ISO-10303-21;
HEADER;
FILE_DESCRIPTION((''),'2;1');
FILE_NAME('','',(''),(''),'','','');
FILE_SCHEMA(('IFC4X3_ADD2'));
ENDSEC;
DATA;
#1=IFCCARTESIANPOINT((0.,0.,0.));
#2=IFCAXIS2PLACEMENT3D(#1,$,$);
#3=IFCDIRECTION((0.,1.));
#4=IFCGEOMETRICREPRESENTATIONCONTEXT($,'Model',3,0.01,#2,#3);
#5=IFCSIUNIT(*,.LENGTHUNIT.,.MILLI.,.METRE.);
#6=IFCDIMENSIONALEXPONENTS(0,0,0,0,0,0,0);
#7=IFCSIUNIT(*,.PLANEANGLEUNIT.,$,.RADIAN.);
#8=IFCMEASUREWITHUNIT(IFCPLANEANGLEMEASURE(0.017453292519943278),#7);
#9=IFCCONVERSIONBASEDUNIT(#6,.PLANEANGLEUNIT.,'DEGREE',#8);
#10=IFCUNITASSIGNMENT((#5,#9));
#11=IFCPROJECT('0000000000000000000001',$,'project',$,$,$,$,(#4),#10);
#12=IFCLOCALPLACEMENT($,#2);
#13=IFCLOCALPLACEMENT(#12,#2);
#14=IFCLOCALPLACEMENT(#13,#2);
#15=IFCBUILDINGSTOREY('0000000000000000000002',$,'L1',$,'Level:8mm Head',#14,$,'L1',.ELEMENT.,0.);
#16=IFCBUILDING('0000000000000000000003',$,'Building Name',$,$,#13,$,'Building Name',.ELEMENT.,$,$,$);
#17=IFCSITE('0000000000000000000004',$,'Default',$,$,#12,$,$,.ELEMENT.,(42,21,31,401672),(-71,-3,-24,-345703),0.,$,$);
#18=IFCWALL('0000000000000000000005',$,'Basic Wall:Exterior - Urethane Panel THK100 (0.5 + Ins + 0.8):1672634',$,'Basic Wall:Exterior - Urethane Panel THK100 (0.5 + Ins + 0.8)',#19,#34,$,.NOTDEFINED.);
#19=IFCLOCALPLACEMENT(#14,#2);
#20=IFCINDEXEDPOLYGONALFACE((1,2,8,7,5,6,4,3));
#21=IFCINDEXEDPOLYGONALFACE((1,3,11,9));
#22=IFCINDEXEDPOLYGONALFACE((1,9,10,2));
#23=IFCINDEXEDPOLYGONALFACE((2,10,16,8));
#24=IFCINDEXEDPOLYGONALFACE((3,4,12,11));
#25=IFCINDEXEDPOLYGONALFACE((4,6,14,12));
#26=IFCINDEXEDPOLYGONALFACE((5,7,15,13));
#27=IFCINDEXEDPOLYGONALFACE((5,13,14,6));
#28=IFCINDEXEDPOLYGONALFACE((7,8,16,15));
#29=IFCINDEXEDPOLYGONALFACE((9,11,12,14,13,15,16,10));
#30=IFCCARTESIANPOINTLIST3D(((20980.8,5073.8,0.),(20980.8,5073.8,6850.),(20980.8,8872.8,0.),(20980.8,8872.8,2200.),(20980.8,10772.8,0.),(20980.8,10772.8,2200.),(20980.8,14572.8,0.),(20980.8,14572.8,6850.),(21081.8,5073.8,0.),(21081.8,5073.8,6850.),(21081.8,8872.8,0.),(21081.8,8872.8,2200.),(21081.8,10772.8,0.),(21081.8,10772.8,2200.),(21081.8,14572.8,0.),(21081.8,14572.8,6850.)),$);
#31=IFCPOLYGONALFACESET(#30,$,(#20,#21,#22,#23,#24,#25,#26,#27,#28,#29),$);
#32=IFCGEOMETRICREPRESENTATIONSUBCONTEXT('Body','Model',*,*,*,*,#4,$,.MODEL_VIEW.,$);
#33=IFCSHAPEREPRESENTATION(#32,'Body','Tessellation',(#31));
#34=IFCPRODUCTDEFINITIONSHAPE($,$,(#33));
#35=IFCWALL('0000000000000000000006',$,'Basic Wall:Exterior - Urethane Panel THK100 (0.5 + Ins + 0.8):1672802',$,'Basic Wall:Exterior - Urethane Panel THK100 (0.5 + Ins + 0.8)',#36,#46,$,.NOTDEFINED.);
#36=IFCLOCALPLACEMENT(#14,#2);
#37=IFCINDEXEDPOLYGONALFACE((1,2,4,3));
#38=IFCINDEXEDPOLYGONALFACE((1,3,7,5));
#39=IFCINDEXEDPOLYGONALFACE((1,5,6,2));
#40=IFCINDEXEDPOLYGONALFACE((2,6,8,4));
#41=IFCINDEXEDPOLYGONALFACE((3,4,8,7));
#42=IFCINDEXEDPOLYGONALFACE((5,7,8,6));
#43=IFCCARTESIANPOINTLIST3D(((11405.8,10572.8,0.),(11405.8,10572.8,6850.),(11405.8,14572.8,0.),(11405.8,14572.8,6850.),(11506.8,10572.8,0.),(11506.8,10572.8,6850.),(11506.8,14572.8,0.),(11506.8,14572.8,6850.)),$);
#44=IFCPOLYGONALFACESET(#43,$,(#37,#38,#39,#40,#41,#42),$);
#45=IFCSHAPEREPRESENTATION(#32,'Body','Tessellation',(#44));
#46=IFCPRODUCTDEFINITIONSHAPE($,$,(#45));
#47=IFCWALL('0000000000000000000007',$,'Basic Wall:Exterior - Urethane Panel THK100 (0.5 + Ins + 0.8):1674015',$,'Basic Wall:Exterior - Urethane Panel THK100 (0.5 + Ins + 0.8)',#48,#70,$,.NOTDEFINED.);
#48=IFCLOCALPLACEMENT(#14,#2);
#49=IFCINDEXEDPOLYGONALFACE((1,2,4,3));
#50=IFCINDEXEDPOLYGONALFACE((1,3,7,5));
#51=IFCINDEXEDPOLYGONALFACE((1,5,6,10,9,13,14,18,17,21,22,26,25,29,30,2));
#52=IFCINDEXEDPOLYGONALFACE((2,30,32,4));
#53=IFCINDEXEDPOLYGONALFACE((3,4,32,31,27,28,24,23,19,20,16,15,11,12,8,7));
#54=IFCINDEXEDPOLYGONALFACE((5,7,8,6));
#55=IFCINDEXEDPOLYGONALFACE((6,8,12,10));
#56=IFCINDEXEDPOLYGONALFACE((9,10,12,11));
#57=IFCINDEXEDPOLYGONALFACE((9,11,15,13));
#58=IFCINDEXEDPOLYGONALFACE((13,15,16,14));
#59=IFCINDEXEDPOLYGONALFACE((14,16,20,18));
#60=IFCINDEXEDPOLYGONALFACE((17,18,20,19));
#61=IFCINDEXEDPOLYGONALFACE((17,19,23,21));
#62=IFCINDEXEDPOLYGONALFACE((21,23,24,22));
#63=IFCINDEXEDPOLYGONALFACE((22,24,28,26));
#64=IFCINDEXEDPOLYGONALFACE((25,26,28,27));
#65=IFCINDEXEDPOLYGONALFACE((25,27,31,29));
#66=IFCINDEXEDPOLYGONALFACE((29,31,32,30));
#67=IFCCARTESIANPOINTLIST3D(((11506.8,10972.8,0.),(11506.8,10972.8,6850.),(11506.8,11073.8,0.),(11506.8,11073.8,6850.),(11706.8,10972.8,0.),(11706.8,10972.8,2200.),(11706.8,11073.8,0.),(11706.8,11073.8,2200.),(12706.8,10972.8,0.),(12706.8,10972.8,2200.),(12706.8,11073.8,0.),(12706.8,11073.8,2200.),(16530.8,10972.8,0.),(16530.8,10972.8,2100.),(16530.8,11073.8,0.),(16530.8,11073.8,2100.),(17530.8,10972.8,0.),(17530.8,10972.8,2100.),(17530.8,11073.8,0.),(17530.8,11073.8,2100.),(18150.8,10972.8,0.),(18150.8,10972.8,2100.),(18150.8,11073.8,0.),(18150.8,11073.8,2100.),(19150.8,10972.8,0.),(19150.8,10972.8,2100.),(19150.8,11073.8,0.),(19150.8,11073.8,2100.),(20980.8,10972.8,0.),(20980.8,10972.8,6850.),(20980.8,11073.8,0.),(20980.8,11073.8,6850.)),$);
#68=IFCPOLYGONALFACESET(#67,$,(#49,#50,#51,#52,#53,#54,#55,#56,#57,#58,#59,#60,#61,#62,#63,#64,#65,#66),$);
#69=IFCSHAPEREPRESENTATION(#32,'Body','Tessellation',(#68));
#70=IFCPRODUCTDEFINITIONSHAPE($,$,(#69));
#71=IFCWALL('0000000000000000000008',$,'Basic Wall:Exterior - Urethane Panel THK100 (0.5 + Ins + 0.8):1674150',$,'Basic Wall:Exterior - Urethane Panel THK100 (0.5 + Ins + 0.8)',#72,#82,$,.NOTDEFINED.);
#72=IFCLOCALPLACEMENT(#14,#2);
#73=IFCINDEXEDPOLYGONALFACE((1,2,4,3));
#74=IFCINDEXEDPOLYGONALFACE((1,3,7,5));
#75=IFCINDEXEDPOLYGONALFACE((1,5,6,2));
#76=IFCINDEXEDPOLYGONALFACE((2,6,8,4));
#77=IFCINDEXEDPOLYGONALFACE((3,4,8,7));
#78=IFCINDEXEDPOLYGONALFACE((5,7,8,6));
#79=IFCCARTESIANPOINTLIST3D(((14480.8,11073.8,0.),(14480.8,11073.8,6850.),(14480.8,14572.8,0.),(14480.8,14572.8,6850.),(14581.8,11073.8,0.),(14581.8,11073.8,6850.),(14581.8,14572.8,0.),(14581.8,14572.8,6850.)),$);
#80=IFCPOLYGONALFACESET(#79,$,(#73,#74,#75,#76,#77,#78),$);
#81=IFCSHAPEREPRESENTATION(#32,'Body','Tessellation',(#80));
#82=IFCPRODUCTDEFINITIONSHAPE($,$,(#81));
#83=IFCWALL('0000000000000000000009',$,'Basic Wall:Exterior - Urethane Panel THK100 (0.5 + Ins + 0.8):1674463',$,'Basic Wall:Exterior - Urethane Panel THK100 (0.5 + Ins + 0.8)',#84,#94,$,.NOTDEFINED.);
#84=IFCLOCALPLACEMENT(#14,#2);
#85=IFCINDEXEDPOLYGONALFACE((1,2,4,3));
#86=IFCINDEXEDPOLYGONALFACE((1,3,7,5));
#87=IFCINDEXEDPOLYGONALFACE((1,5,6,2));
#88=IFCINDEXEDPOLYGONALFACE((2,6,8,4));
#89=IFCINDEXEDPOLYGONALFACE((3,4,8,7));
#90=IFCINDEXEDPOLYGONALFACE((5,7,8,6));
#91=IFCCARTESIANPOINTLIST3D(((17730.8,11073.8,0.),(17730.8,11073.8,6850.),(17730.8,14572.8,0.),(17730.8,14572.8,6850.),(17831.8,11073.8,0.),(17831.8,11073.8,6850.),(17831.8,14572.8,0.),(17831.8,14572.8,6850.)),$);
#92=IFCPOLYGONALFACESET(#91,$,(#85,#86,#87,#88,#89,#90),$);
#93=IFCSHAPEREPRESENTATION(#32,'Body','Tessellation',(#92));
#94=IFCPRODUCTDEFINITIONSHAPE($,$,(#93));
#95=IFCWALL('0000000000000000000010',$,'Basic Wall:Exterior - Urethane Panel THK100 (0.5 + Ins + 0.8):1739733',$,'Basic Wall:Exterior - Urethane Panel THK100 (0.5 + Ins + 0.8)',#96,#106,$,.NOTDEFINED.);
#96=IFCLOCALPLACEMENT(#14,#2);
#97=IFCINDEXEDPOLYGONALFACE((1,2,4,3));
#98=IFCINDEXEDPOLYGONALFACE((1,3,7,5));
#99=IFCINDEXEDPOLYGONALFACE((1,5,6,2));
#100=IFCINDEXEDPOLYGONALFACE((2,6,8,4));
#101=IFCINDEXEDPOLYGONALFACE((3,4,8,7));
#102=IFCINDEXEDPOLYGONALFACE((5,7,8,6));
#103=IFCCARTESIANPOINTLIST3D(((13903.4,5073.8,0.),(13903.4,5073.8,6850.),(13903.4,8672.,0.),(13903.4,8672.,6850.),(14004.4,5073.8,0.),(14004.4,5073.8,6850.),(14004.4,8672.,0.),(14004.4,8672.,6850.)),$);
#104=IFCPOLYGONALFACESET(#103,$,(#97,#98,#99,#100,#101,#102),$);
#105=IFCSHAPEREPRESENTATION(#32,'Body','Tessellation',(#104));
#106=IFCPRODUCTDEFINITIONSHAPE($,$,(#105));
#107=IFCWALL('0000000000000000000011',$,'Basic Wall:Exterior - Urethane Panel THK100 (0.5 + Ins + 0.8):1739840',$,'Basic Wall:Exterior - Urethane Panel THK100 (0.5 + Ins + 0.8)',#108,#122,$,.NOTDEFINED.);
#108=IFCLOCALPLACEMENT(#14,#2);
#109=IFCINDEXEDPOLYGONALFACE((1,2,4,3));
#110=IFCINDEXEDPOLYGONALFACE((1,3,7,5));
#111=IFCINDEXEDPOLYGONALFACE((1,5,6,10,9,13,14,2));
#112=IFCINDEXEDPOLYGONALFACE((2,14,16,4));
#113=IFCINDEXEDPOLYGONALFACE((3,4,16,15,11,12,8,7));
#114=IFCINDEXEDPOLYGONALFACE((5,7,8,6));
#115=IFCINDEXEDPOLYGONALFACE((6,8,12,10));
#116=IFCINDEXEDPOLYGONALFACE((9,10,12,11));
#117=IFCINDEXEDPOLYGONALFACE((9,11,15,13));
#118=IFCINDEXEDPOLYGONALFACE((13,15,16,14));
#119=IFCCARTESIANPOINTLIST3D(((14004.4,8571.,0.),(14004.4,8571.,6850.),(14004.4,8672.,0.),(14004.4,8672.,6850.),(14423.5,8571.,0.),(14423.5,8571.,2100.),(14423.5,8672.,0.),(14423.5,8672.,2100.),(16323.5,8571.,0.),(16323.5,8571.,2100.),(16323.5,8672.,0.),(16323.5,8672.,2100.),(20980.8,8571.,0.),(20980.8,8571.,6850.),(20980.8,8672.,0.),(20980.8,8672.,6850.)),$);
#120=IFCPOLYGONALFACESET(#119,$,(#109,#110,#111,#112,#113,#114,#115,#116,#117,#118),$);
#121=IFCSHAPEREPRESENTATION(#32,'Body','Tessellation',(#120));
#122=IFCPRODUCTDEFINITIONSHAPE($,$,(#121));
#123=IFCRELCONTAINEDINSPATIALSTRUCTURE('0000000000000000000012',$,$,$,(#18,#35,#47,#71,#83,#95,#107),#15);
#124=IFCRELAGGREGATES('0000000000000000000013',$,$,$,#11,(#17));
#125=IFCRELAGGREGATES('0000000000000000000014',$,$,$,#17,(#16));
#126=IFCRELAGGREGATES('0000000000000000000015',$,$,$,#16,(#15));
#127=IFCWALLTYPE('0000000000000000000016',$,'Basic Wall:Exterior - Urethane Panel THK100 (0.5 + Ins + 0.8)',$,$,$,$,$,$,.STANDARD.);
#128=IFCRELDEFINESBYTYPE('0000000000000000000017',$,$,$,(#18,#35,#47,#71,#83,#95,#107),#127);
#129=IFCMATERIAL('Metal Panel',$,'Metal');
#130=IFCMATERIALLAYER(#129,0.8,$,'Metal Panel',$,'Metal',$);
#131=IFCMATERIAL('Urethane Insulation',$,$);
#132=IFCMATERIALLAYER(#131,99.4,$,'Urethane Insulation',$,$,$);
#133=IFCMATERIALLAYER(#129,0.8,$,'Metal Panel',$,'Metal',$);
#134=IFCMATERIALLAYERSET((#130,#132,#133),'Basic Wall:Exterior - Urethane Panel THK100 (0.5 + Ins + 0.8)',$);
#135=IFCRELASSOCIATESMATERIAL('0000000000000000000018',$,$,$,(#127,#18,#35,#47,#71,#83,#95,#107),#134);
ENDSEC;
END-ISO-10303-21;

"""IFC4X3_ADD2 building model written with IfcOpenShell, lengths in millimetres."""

from ifc_helpers import new_model, entity, si_unit, converted_unit, direction, frame, frame_2d, origin, place, context, subcontext, project, spatial, polyline, rectangle, extrude, clip, bounded_halfspace, material, layer, layer_set, type_object, element, save


model = new_model("IFC4X3_ADD2")

# Units and contexts
model_context = context("Model", 3, precision=0.01, world=origin(), true_north=direction((0.0, 1.0)))
body_context = subcontext(model_context, "Body", "Model", "MODEL_VIEW")
ifc_project = project(units=[si_unit("LENGTHUNIT", "METRE", prefix="MILLI"), converted_unit("PLANEANGLEUNIT", "DEGREE", entity("IfcPlaneAngleMeasure", 0.017453292519943278), si_unit("PLANEANGLEUNIT", "RADIAN"), dimensions=[0, 0, 0, 0, 0, 0, 0])], contexts=[model_context])

# Site, building, storey
site_placement = place(None, origin())
site = spatial("IfcSite", under=ifc_project, at=site_placement, Name="Default", CompositionType="ELEMENT", RefLatitude=(42, 21, 31, 401672), RefLongitude=(-71, -3, -24, -345703), RefElevation=0.0)
building_placement = place(site_placement, origin())
building = spatial("IfcBuilding", under=site, at=building_placement, Name="Building Name", LongName="Building Name", CompositionType="ELEMENT")
storey_placement = place(building_placement, origin())
storey = spatial("IfcBuildingStorey", under=building, at=storey_placement, Name="L1", ObjectType="Level:8mm Head", LongName="L1", CompositionType="ELEMENT", Elevation=0.0)

# Wall, opening
ifc_material_1 = material(Name="Metal Panel", Category="Metal")
ifc_layer_1 = layer(ifc_material_1, 0.8, Name="Metal Panel", Category="Metal")
ifc_material_2 = material(Name="Urethane Insulation")
ifc_layer_2 = layer(ifc_material_2, 99.4, Name="Urethane Insulation")
ifc_layer_3 = layer(ifc_material_1, 0.8, Name="Metal Panel", Category="Metal")
ifc_layer_set = layer_set([ifc_layer_1, ifc_layer_2, ifc_layer_3], Name="Basic Wall:Exterior - Urethane Panel THK100 (0.5 + Ins + 0.8)")
wall_type = type_object("IfcWallType", Name="Basic Wall:Exterior - Urethane Panel THK100 (0.5 + Ins + 0.8)", PredefinedType="STANDARD", material=ifc_layer_set)
wall_1_placement = place(storey_placement, frame((21031.3, 5073.8, 0.0), z_axis=(0.0, 0.0, 1.0), x_axis=(0.0, 1.0, 0.0)))
wall_1 = element("IfcWall", 1, at=wall_1_placement, inside=storey, type_object=wall_type, material=ifc_layer_set, Name="Basic Wall:Exterior - Urethane Panel THK100 (0.5 + Ins + 0.8):1672634", ObjectType="Basic Wall:Exterior - Urethane Panel THK100 (0.5 + Ins + 0.8)", PredefinedType="NOTDEFINED", context=body_context, shape_type="Clipping", body=[
    clip(extrude(rectangle(XDim=9499.0, YDim=101.0, at=frame_2d((4749.5, 0.0), x_axis=(-1.0, 0.0))), origin(), (0.0, 0.0, 1.0), 6850.0), bounded_halfspace(frame((0.0, -50.5, 6850.0), z_axis=(0.0, 0.0, -1.0), x_axis=(0.0, -1.0, 0.0)), True, frame((0.0, -50.5, 6850.0)), polyline([(0.0, 0.0), (9499.0, 0.0), (9499.0, 101.0), (6000.0, 101.0), (5899.0, 101.0), (3598.2, 101.0), (3497.2, 101.0), (0.0, 101.0), (0.0, 0.0)]))),
])
opening_1_placement = place(wall_1_placement, frame((3799.0, -50.5, 0.0)))
element("IfcOpeningElement", 2, at=opening_1_placement, cuts=wall_1, PredefinedType="OPENING", context=body_context, shape_type="SweptSolid", body=[
    extrude(rectangle(XDim=2200.0, YDim=1900.0, at=frame_2d((1100.0, 950.0), x_axis=(1.0, 0.0))), frame((0.0, 0.0, 0.0), z_axis=(0.0, 1.0, 0.0), x_axis=(0.0, 0.0, 1.0)), (0.0, 0.0, 1.0), 101.0),
])

# Wall
wall_2_placement = place(storey_placement, frame((11456.3, 14572.8, 0.0), z_axis=(0.0, 0.0, 1.0), x_axis=(0.0, -1.0, 0.0)))
element("IfcWall", 3, at=wall_2_placement, inside=storey, type_object=wall_type, material=ifc_layer_set, Name="Basic Wall:Exterior - Urethane Panel THK100 (0.5 + Ins + 0.8):1672802", ObjectType="Basic Wall:Exterior - Urethane Panel THK100 (0.5 + Ins + 0.8)", PredefinedType="NOTDEFINED", context=body_context, shape_type="Clipping", body=[
    clip(extrude(rectangle(XDim=4000.0, YDim=101.0, at=frame_2d((2000.0, 0.0), x_axis=(-1.0, 0.0))), origin(), (0.0, 0.0, 1.0), 6850.0), bounded_halfspace(frame((0.0, -50.5, 6850.0), z_axis=(0.0, 0.0, -1.0), x_axis=(0.0, 1.0, 0.0)), True, frame((0.0, -50.5, 6850.0)), polyline([(0.0, 0.0), (3899.0, 0.0), (4000.0, 0.0), (4000.0, 101.0), (3600.0, 101.0), (3499.0, 101.0), (0.0, 101.0), (0.0, 0.0)]))),
])

# Wall, openings
wall_3_placement = place(storey_placement, frame((11506.8, 11023.3, 0.0)))
wall_3 = element("IfcWall", 4, at=wall_3_placement, inside=storey, type_object=wall_type, material=ifc_layer_set, Name="Basic Wall:Exterior - Urethane Panel THK100 (0.5 + Ins + 0.8):1674015", ObjectType="Basic Wall:Exterior - Urethane Panel THK100 (0.5 + Ins + 0.8)", PredefinedType="NOTDEFINED", context=body_context, shape_type="Clipping", body=[
    clip(extrude(rectangle(XDim=9474.0, YDim=101.0, at=frame_2d((4737.0, 0.0), x_axis=(1.0, 0.0))), origin(), (0.0, 0.0, 1.0), 6850.0), bounded_halfspace(frame((0.0, -50.5, 6850.0), z_axis=(0.0, 0.0, -1.0), x_axis=(1.0, 0.0, 0.0)), True, frame((0.0, -50.5, 6850.0)), polyline([(0.0, 0.0), (9474.0, 0.0), (9474.0, 101.0), (6325.0, 101.0), (6224.0, 101.0), (3075.0, 101.0), (2974.0, 101.0), (0.0, 101.0), (0.0, 0.0)]))),
])
opening_2_placement = place(wall_3_placement, frame((200.0, -50.5, 0.0)))
element("IfcOpeningElement", 5, at=opening_2_placement, cuts=wall_3, PredefinedType="OPENING", context=body_context, shape_type="SweptSolid", body=[
    extrude(rectangle(XDim=2200.0, YDim=1000.0, at=frame_2d((1100.0, 500.0), x_axis=(1.0, 0.0))), frame((0.0, 0.0, 0.0), z_axis=(0.0, 1.0, 0.0), x_axis=(0.0, 0.0, 1.0)), (0.0, 0.0, 1.0), 101.0),
])
opening_3_placement = place(wall_3_placement, frame((5024.0, -50.5, 0.0)))
element("IfcOpeningElement", 6, at=opening_3_placement, cuts=wall_3, PredefinedType="OPENING", context=body_context, shape_type="SweptSolid", body=[
    extrude(rectangle(XDim=2100.0, YDim=1000.0, at=frame_2d((1050.0, 500.0), x_axis=(1.0, 0.0))), frame((0.0, 0.0, 0.0), z_axis=(0.0, 1.0, 0.0), x_axis=(0.0, 0.0, 1.0)), (0.0, 0.0, 1.0), 101.0),
])
opening_4_placement = place(wall_3_placement, frame((6644.0, -50.5, 0.0)))
element("IfcOpeningElement", 7, at=opening_4_placement, cuts=wall_3, PredefinedType="OPENING", context=body_context, shape_type="SweptSolid", body=[
    extrude(rectangle(XDim=2100.0, YDim=1000.0, at=frame_2d((1050.0, 500.0), x_axis=(1.0, 0.0))), frame((0.0, 0.0, 0.0), z_axis=(0.0, 1.0, 0.0), x_axis=(0.0, 0.0, 1.0)), (0.0, 0.0, 1.0), 101.0),
])

# Walls
wall_4_placement = place(storey_placement, frame((14531.3, 11073.8, 0.0), z_axis=(0.0, 0.0, 1.0), x_axis=(0.0, 1.0, 0.0)))
element("IfcWall", 8, at=wall_4_placement, inside=storey, type_object=wall_type, material=ifc_layer_set, Name="Basic Wall:Exterior - Urethane Panel THK100 (0.5 + Ins + 0.8):1674150", ObjectType="Basic Wall:Exterior - Urethane Panel THK100 (0.5 + Ins + 0.8)", PredefinedType="NOTDEFINED", context=body_context, shape_type="Clipping", body=[
    clip(extrude(rectangle(XDim=3499.0, YDim=101.0, at=frame_2d((1749.5, 0.0), x_axis=(-1.0, 0.0))), origin(), (0.0, 0.0, 1.0), 6850.0), bounded_halfspace(frame((0.0, -50.5, 6850.0), z_axis=(0.0, 0.0, -1.0), x_axis=(0.0, -1.0, 0.0)), True, frame((0.0, -50.5, 6850.0)), polyline([(0.0, 0.0), (3499.0, 0.0), (3499.0, 101.0), (0.0, 101.0), (0.0, 0.0)]))),
])
wall_5_placement = place(storey_placement, frame((17781.3, 14572.8, 0.0), z_axis=(0.0, 0.0, 1.0), x_axis=(0.0, -1.0, 0.0)))
element("IfcWall", 9, at=wall_5_placement, inside=storey, type_object=wall_type, material=ifc_layer_set, Name="Basic Wall:Exterior - Urethane Panel THK100 (0.5 + Ins + 0.8):1674463", ObjectType="Basic Wall:Exterior - Urethane Panel THK100 (0.5 + Ins + 0.8)", PredefinedType="NOTDEFINED", context=body_context, shape_type="Clipping", body=[
    clip(extrude(rectangle(XDim=3499.0, YDim=101.0, at=frame_2d((1749.5, 0.0), x_axis=(-1.0, 0.0))), origin(), (0.0, 0.0, 1.0), 6850.0), bounded_halfspace(frame((0.0, -50.5, 6850.0), z_axis=(0.0, 0.0, -1.0), x_axis=(0.0, 1.0, 0.0)), True, frame((0.0, -50.5, 6850.0)), polyline([(0.0, 0.0), (3499.0, 0.0), (3499.0, 101.0), (0.0, 101.0), (0.0, 0.0)]))),
])
wall_6_placement = place(storey_placement, frame((13953.9, 5073.8, 0.0), z_axis=(0.0, 0.0, 1.0), x_axis=(0.0, 1.0, 0.0)))
element("IfcWall", 10, at=wall_6_placement, inside=storey, type_object=wall_type, material=ifc_layer_set, Name="Basic Wall:Exterior - Urethane Panel THK100 (0.5 + Ins + 0.8):1739733", ObjectType="Basic Wall:Exterior - Urethane Panel THK100 (0.5 + Ins + 0.8)", PredefinedType="NOTDEFINED", context=body_context, shape_type="Clipping", body=[
    clip(extrude(rectangle(XDim=3598.2, YDim=101.0, at=frame_2d((1799.1, 0.0), x_axis=(-1.0, 0.0))), origin(), (0.0, 0.0, 1.0), 6850.0), bounded_halfspace(frame((0.0, -50.5, 6850.0), z_axis=(0.0, 0.0, -1.0), x_axis=(0.0, -1.0, 0.0)), True, frame((0.0, -50.5, 6850.0)), polyline([(0.0, 0.0), (3497.2, 0.0), (3598.2, 0.0), (3598.2, 101.0), (0.0, 101.0), (0.0, 0.0)]))),
])

# Wall, opening
wall_7_placement = place(storey_placement, frame((14004.4, 8621.5, 0.0)))
wall_7 = element("IfcWall", 11, at=wall_7_placement, inside=storey, type_object=wall_type, material=ifc_layer_set, Name="Basic Wall:Exterior - Urethane Panel THK100 (0.5 + Ins + 0.8):1739840", ObjectType="Basic Wall:Exterior - Urethane Panel THK100 (0.5 + Ins + 0.8)", PredefinedType="NOTDEFINED", context=body_context, shape_type="Clipping", body=[
    clip(extrude(rectangle(XDim=6976.4, YDim=101.0, at=frame_2d((3488.2, 0.0), x_axis=(-1.0, 0.0))), origin(), (0.0, 0.0, 1.0), 6850.0), bounded_halfspace(frame((0.0, -50.5, 6850.0), z_axis=(0.0, 0.0, -1.0), x_axis=(1.0, 0.0, 0.0)), True, frame((0.0, -50.5, 6850.0)), polyline([(0.0, 0.0), (6976.4, 0.0), (6976.4, 101.0), (0.0, 101.0), (0.0, 0.0)]))),
])
opening_5_placement = place(wall_7_placement, frame((2319.1, 50.5, 0.0)))
element("IfcOpeningElement", 12, at=opening_5_placement, cuts=wall_7, PredefinedType="OPENING", context=body_context, shape_type="SweptSolid", body=[
    extrude(rectangle(XDim=2100.0, YDim=1900.0, at=frame_2d((1050.0, 950.0), x_axis=(1.0, 0.0))), frame((0.0, 0.0, 0.0), z_axis=(0.0, -1.0, 0.0), x_axis=(0.0, 0.0, 1.0)), (0.0, 0.0, 1.0), 101.0),
])

save(model, "model.ifc")
